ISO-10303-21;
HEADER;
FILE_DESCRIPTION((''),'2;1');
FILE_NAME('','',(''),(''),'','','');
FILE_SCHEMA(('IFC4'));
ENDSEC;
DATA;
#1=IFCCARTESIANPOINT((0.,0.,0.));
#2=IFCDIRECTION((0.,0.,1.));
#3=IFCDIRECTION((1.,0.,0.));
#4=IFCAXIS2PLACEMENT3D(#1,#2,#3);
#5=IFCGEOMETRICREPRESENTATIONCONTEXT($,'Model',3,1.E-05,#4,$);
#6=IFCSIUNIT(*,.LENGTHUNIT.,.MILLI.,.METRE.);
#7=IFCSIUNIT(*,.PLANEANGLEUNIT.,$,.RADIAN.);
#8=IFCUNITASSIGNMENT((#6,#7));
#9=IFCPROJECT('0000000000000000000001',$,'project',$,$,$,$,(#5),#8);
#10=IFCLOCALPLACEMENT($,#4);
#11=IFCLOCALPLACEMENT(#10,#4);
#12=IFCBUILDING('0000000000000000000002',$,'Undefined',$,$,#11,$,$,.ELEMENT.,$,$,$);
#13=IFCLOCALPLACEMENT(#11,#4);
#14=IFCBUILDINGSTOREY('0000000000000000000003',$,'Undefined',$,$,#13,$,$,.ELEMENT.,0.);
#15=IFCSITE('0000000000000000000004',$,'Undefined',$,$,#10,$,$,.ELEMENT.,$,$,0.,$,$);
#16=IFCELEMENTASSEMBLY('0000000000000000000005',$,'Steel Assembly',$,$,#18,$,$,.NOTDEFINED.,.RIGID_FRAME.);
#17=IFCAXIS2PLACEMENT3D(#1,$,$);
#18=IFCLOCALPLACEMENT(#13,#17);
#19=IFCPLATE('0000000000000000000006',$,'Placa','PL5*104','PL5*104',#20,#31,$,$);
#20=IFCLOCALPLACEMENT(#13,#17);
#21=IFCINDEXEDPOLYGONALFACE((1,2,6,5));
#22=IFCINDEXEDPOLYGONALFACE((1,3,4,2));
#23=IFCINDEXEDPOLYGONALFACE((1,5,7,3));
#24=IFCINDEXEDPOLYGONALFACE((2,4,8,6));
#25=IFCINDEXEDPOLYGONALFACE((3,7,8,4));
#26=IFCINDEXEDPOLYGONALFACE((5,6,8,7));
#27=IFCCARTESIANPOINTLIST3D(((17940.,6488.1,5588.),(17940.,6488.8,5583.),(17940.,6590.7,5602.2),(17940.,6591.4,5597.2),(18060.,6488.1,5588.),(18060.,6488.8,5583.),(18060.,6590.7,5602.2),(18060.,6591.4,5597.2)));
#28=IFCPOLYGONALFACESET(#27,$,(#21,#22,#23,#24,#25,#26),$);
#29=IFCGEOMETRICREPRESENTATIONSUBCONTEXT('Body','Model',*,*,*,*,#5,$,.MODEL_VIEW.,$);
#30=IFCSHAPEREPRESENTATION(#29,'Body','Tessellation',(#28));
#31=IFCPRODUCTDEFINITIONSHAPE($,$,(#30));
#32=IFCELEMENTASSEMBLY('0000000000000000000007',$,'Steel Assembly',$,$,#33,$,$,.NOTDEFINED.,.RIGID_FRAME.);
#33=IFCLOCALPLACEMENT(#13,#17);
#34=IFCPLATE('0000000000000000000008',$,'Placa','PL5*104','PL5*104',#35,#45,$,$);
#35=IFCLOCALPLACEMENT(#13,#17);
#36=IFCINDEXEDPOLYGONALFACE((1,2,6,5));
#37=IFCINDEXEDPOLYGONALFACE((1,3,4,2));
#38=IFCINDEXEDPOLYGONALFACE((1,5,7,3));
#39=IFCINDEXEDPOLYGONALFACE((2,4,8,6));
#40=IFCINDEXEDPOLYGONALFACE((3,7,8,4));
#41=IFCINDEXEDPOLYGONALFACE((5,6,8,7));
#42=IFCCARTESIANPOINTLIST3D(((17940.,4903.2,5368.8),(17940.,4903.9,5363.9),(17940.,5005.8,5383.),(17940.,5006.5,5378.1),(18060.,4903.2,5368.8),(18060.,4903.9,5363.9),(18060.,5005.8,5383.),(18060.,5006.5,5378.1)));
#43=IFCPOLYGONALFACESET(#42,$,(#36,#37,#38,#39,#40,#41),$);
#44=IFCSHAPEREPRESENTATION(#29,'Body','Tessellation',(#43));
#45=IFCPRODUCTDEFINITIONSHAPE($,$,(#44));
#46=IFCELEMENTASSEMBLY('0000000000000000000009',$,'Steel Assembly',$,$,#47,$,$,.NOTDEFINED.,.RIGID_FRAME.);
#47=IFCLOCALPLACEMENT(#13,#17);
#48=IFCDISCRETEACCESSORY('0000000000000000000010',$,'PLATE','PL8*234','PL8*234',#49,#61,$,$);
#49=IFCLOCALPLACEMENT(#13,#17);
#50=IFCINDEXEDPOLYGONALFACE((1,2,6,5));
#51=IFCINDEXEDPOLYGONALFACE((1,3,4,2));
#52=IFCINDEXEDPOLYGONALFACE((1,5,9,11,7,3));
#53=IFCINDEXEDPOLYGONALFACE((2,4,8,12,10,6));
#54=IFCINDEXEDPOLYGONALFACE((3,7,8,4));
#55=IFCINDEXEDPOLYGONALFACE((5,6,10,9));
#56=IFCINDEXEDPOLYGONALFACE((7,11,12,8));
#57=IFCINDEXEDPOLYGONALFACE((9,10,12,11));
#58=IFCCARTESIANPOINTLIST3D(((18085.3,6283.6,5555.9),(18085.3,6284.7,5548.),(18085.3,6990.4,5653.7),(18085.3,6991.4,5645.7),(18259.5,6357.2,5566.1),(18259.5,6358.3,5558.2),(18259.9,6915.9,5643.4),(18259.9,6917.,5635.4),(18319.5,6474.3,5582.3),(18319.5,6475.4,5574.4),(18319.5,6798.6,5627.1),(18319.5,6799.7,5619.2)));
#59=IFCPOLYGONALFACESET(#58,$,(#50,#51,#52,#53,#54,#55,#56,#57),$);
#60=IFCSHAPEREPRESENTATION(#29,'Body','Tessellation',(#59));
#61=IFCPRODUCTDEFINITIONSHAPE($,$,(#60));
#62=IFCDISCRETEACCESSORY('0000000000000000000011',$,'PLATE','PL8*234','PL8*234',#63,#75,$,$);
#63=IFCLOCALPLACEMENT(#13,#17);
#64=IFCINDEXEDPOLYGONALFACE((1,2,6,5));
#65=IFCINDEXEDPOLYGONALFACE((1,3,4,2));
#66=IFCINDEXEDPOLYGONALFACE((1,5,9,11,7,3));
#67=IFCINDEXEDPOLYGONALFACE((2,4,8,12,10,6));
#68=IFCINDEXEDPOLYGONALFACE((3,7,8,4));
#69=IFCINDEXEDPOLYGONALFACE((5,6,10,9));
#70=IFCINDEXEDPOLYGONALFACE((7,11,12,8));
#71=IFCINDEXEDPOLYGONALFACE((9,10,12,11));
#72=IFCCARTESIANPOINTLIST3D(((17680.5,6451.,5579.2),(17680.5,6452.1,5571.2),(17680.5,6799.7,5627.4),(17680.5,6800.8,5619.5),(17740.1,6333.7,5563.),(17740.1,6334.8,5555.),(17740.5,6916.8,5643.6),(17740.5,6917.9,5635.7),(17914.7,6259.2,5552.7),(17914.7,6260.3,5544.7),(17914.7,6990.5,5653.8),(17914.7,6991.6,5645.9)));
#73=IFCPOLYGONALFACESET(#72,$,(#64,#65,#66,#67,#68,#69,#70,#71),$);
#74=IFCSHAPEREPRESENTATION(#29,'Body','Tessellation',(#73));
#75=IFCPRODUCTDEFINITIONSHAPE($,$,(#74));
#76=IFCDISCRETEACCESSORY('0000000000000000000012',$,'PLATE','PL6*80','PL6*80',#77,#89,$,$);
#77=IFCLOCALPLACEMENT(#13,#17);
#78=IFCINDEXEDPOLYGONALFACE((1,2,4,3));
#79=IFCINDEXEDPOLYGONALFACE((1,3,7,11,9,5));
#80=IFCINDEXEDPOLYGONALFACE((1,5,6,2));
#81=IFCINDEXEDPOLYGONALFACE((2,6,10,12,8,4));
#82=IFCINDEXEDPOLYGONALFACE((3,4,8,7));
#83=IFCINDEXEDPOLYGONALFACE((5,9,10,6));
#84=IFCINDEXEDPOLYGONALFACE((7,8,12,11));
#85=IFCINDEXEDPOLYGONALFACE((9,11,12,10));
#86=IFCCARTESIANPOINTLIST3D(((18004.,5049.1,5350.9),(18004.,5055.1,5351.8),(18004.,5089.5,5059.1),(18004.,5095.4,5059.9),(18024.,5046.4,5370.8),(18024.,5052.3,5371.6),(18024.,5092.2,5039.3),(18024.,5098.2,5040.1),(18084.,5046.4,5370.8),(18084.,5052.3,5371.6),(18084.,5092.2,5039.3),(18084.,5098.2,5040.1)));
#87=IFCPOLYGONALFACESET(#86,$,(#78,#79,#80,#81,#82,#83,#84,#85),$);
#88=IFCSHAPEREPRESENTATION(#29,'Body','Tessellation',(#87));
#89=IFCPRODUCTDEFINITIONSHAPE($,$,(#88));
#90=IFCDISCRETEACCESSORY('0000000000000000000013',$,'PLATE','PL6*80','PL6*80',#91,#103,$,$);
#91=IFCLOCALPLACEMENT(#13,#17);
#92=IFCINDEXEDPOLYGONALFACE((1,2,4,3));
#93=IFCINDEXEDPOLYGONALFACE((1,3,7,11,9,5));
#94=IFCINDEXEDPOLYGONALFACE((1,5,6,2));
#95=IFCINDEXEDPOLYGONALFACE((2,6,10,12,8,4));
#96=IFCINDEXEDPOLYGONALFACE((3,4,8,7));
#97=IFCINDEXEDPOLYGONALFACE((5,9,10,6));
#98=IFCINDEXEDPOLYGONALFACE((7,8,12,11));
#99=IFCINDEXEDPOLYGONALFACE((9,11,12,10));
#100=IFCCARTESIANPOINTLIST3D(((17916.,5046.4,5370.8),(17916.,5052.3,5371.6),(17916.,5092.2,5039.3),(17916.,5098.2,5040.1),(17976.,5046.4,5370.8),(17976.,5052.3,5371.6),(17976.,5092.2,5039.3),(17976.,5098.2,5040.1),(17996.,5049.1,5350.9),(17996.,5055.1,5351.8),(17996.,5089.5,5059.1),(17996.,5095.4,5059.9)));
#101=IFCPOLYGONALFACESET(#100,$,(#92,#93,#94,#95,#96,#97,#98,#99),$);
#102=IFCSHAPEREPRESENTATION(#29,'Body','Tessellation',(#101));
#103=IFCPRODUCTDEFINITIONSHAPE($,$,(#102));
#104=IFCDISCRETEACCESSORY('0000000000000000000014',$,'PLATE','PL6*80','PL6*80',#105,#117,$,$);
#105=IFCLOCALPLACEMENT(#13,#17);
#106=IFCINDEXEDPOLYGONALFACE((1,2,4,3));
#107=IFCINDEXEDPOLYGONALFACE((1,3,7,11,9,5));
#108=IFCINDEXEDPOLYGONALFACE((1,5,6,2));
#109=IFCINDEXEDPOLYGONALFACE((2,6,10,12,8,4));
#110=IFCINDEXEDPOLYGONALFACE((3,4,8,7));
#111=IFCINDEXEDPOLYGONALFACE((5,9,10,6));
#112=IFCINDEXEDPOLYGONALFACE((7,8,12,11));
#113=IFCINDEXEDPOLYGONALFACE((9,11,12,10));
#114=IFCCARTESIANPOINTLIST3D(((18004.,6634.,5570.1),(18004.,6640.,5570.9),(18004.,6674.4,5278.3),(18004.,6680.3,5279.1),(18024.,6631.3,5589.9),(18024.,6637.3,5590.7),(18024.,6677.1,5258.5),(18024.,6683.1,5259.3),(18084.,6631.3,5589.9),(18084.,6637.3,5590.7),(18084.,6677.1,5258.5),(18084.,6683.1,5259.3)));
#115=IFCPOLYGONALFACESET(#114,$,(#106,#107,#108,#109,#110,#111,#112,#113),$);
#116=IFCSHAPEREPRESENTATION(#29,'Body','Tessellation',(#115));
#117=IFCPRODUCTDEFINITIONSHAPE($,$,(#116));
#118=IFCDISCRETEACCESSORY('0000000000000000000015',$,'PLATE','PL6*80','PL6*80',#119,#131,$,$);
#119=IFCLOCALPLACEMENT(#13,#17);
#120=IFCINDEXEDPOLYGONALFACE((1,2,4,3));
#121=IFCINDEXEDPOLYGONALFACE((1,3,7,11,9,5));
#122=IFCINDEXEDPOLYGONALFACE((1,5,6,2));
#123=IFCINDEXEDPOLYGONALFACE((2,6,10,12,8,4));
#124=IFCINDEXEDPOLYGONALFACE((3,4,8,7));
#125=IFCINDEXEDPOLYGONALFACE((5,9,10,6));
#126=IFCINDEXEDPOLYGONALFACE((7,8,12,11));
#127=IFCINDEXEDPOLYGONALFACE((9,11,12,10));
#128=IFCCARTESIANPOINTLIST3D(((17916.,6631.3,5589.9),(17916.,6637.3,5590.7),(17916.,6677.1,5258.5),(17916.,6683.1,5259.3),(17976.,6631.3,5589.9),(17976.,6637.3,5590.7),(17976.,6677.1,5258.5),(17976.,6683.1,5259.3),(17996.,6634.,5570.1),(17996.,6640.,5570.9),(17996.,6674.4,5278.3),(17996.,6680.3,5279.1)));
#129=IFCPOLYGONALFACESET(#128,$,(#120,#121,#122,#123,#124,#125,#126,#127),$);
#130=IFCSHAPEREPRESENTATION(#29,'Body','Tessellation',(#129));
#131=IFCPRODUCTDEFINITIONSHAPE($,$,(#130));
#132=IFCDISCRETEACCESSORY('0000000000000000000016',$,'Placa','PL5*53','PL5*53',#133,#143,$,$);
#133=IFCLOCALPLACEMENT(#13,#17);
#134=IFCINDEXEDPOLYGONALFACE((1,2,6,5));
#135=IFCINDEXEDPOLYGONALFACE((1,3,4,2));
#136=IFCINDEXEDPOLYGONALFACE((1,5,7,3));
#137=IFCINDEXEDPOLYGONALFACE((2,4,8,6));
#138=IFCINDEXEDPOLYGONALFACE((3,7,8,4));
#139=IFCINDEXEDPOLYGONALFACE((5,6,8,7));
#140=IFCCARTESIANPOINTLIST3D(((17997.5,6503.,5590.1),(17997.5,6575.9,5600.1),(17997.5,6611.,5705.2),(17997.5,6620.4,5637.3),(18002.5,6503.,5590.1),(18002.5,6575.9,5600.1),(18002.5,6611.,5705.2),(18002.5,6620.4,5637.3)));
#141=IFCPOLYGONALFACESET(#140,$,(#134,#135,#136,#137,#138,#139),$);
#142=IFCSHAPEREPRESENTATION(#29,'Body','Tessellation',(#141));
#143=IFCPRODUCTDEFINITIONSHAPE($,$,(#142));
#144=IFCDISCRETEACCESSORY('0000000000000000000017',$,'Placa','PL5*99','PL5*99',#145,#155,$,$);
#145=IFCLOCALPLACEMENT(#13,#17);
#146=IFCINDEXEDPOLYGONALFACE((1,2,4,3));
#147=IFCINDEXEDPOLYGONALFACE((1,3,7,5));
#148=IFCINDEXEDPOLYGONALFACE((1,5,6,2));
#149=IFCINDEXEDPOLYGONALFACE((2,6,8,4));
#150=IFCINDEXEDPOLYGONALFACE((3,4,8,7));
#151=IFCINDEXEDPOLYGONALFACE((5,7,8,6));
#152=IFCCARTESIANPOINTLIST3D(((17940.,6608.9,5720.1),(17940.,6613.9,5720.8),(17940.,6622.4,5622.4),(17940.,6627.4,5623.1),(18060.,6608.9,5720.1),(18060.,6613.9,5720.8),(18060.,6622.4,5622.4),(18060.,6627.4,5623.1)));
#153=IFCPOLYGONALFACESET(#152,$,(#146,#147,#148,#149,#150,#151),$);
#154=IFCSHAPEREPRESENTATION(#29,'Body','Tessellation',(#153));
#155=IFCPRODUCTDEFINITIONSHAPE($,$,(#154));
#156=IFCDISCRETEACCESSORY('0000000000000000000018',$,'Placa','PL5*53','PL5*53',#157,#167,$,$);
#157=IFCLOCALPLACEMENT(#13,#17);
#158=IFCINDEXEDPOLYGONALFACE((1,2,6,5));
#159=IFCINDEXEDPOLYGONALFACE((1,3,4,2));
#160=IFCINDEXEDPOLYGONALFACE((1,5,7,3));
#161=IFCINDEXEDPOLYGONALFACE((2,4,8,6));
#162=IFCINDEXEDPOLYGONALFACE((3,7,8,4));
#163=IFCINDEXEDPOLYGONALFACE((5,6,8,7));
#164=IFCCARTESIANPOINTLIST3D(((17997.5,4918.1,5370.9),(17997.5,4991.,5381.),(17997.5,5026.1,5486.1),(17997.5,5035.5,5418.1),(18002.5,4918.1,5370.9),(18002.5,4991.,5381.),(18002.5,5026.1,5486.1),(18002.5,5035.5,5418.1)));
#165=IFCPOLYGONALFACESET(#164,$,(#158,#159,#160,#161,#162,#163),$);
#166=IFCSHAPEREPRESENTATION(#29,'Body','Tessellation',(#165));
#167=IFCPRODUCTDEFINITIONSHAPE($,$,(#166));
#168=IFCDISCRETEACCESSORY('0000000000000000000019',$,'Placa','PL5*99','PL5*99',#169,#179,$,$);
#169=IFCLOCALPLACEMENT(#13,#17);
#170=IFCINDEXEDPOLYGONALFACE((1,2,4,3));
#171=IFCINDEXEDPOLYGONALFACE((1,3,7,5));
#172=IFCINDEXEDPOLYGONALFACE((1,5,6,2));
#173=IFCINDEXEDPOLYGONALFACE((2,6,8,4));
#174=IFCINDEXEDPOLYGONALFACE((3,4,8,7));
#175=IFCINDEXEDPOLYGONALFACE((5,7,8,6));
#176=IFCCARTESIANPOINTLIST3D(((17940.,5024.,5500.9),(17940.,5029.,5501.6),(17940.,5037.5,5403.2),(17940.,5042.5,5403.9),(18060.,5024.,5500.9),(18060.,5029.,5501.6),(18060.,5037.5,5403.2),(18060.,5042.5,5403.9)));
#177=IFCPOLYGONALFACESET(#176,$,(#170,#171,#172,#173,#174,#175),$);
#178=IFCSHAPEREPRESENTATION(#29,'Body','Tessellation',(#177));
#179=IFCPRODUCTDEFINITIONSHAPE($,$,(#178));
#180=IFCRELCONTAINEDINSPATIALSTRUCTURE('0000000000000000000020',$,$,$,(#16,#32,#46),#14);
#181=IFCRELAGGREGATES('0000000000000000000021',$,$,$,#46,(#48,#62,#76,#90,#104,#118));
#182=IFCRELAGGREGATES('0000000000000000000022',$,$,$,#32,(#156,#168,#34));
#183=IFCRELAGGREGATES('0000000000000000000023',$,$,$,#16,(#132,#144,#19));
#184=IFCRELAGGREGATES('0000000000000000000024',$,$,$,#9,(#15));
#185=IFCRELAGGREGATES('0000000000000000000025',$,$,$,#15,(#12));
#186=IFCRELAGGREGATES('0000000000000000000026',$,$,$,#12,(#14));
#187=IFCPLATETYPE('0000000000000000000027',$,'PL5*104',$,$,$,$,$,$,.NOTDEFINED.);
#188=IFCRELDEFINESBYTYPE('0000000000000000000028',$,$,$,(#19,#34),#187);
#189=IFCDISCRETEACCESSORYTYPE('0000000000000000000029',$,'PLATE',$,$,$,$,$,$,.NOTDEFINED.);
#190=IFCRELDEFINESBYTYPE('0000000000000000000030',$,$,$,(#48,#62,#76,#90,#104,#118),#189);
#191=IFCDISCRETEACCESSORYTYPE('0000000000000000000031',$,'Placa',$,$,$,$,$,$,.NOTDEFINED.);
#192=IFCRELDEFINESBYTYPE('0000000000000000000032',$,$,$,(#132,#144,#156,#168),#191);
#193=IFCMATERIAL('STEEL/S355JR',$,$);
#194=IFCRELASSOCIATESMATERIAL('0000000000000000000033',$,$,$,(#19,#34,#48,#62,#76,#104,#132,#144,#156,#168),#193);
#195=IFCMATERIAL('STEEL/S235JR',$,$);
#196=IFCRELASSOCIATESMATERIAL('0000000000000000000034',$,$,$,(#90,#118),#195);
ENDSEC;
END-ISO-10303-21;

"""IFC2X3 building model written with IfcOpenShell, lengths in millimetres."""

from ifc_helpers import new_model, si_unit, frame, origin_with_axes, place, context, subcontext, project, spatial, polyline, outline, extrude, material, type_object, element, aggregate, save


model = new_model("IFC2X3")

# Units and contexts
model_context = context("Model", 3, precision=1e-05, world=origin_with_axes())
body_context = subcontext(model_context, "Body", "Model", "MODEL_VIEW")
ifc_project = project(units=[si_unit("LENGTHUNIT", "METRE", prefix="MILLI"), si_unit("PLANEANGLEUNIT", "RADIAN")], contexts=[model_context])

# Site, building, storey
site_placement = place(None, origin_with_axes())
site = spatial("IfcSite", under=ifc_project, at=site_placement, Name="Undefined", CompositionType="ELEMENT", RefElevation=0.0)
building_placement = place(site_placement, origin_with_axes())
building = spatial("IfcBuilding", under=site, at=building_placement, Name="Undefined", CompositionType="ELEMENT")
storey_placement = place(building_placement, origin_with_axes())
storey = spatial("IfcBuildingStorey", under=building, at=storey_placement, Name="Undefined", CompositionType="ELEMENT", Elevation=0.0)

# Shared definitions
ifc_material_1 = material(Name="STEEL/S355JR")

# Element assemblies, plates
assembly_1_placement = place(storey_placement, origin_with_axes())
assembly_1 = element("IfcElementAssembly", 1, at=assembly_1_placement, inside=storey, Name="Steel Assembly", AssemblyPlace="NOTDEFINED", PredefinedType="RIGID_FRAME")
plate_type = type_object("IfcPlateType", Name="PL5*104", PredefinedType="NOTDEFINED")
plate_1_placement = place(assembly_1_placement, frame((17940.0, 6591.1, 5599.7), z_axis=(0.0, -0.136905, 0.990584), x_axis=(0.0, -0.990584, -0.136905)))
plate_1 = element("IfcPlate", 2, at=plate_1_placement, type_object=plate_type, material=ifc_material_1, Name="Placa", Description="PL5*104", ObjectType="PL5*104", context=body_context, shape_type="SweptSolid", body=[
    extrude(outline(polyline([(0.0, 0.0), (103.6, 0.0), (103.6, 120.0), (0.0, 120.0), (0.0, 0.0)])), frame((0.0, 0.0, -2.5), z_axis=(0.0, 0.0, 1.0), x_axis=(1.0, 0.0, 0.0)), (0.0, 0.0, 1.0), 5.0),
])
assembly_2_placement = place(storey_placement, origin_with_axes())
assembly_2 = element("IfcElementAssembly", 3, at=assembly_2_placement, inside=storey, Name="Steel Assembly", AssemblyPlace="NOTDEFINED", PredefinedType="RIGID_FRAME")
plate_2_placement = place(assembly_2_placement, frame((17940.0, 5006.2, 5380.5), z_axis=(0.0, -0.136905, 0.990584), x_axis=(0.0, -0.990584, -0.136905)))
plate_2 = element("IfcPlate", 4, at=plate_2_placement, type_object=plate_type, material=ifc_material_1, Name="Placa", Description="PL5*104", ObjectType="PL5*104", context=body_context, shape_type="SweptSolid", body=[
    extrude(outline(polyline([(0.0, 0.0), (103.6, 0.0), (103.6, 120.0), (0.0, 120.0), (0.0, 0.0)])), frame((0.0, 0.0, -2.5), z_axis=(0.0, 0.0, 1.0), x_axis=(1.0, 0.0, 0.0)), (0.0, 0.0, 1.0), 5.0),
])

# Element assembly, discrete accessories
assembly_3_placement = place(storey_placement, origin_with_axes())
assembly_3 = element("IfcElementAssembly", 5, at=assembly_3_placement, inside=storey, Name="Steel Assembly", AssemblyPlace="NOTDEFINED", PredefinedType="RIGID_FRAME")
discrete_accessory_type_1 = type_object("IfcDiscreteAccessoryType", Name="PLATE")
discrete_accessory_1_placement = place(assembly_3_placement, frame((18085.3, 6990.9, 5649.7), z_axis=(-0.000018, -0.13698, 0.990574), x_axis=(0.0, -0.990574, -0.13698)))
discrete_accessory_1 = element("IfcDiscreteAccessory", 6, at=discrete_accessory_1_placement, type_object=discrete_accessory_type_1, material=ifc_material_1, Name="PLATE", Description="PL8*234", ObjectType="PL8*234", context=body_context, shape_type="SweptSolid", body=[
    extrude(outline(polyline([(0.0, 0.0), (713.5, 0.0), (639.1, 174.2), (520.9, 234.3), (193.6, 234.3), (75.2, 174.6), (0.0, 0.0)])), frame((0.0, 0.0, -4.0), z_axis=(0.0, 0.0, 1.0), x_axis=(1.0, 0.0, 0.0)), (0.0, 0.0, 1.0), 8.0),
])
discrete_accessory_2_placement = place(assembly_3_placement, frame((17914.7, 6259.8, 5548.7), z_axis=(-0.000018, -0.13698, 0.990574), x_axis=(0.0, 0.990574, 0.13698)))
discrete_accessory_2 = element("IfcDiscreteAccessory", 7, at=discrete_accessory_2_placement, type_object=discrete_accessory_type_1, material=ifc_material_1, Name="PLATE", Description="PL8*234", ObjectType="PL8*234", context=body_context, shape_type="SweptSolid", body=[
    extrude(outline(polyline([(0.0, 0.0), (738.2, 0.0), (663.9, 174.2), (545.6, 234.3), (193.6, 234.3), (75.2, 174.6), (0.0, 0.0)])), frame((0.0, 0.0, -4.0), z_axis=(0.0, 0.0, 1.0), x_axis=(1.0, 0.0, 0.0)), (0.0, 0.0, 1.0), 8.0),
])
discrete_accessory_3_placement = place(assembly_3_placement, frame((18084.0, 5095.2, 5039.7), z_axis=(0.0, 0.990574, 0.13698), x_axis=(-1.0, 0.0, 0.0)))
discrete_accessory_3 = element("IfcDiscreteAccessory", 8, at=discrete_accessory_3_placement, type_object=discrete_accessory_type_1, material=ifc_material_1, Name="PLATE", Description="PL6*80", ObjectType="PL6*80", context=body_context, shape_type="SweptSolid", body=[
    extrude(outline(polyline([(0.0, 0.0), (60.0, 0.0), (80.0, 20.0), (80.0, 314.6), (60.0, 334.6), (0.0, 334.6), (0.0, 0.0)])), frame((0.0, 0.0, -3.0), z_axis=(0.0, 0.0, 1.0), x_axis=(1.0, 0.0, 0.0)), (0.0, 0.0, 1.0), 6.0),
])
ifc_material_2 = material(Name="STEEL/S235JR")
discrete_accessory_4_placement = place(assembly_3_placement, frame((17996.0, 5095.2, 5039.7), z_axis=(0.0, 0.990574, 0.13698), x_axis=(-1.0, 0.0, 0.0)))
discrete_accessory_4 = element("IfcDiscreteAccessory", 9, at=discrete_accessory_4_placement, type_object=discrete_accessory_type_1, material=ifc_material_2, Name="PLATE", Description="PL6*80", ObjectType="PL6*80", context=body_context, shape_type="SweptSolid", body=[
    extrude(outline(polyline([(0.0, 20.0), (20.0, 0.0), (80.0, 0.0), (80.0, 334.6), (20.0, 334.6), (0.0, 314.6), (0.0, 20.0)])), frame((0.0, 0.0, -3.0), z_axis=(0.0, 0.0, 1.0), x_axis=(1.0, 0.0, 0.0)), (0.0, 0.0, 1.0), 6.0),
])
discrete_accessory_5_placement = place(assembly_3_placement, frame((18084.0, 6680.1, 5258.9), z_axis=(0.0, 0.990574, 0.13698), x_axis=(-1.0, 0.0, 0.0)))
discrete_accessory_5 = element("IfcDiscreteAccessory", 10, at=discrete_accessory_5_placement, type_object=discrete_accessory_type_1, material=ifc_material_1, Name="PLATE", Description="PL6*80", ObjectType="PL6*80", context=body_context, shape_type="SweptSolid", body=[
    extrude(outline(polyline([(0.0, 0.0), (60.0, 0.0), (80.0, 20.0), (80.0, 314.6), (60.0, 334.6), (0.0, 334.6), (0.0, 0.0)])), frame((0.0, 0.0, -3.0), z_axis=(0.0, 0.0, 1.0), x_axis=(1.0, 0.0, 0.0)), (0.0, 0.0, 1.0), 6.0),
])
discrete_accessory_6_placement = place(assembly_3_placement, frame((17996.0, 6680.1, 5258.9), z_axis=(0.0, 0.990574, 0.13698), x_axis=(-1.0, 0.0, 0.0)))
discrete_accessory_6 = element("IfcDiscreteAccessory", 11, at=discrete_accessory_6_placement, type_object=discrete_accessory_type_1, material=ifc_material_2, Name="PLATE", Description="PL6*80", ObjectType="PL6*80", context=body_context, shape_type="SweptSolid", body=[
    extrude(outline(polyline([(0.0, 20.0), (20.0, 0.0), (80.0, 0.0), (80.0, 334.6), (20.0, 334.6), (0.0, 314.6), (0.0, 20.0)])), frame((0.0, 0.0, -3.0), z_axis=(0.0, 0.0, 1.0), x_axis=(1.0, 0.0, 0.0)), (0.0, 0.0, 1.0), 6.0),
])
aggregate(assembly_3, [discrete_accessory_1, discrete_accessory_2, discrete_accessory_3, discrete_accessory_4, discrete_accessory_5, discrete_accessory_6])

# Discrete accessories
discrete_accessory_type_2 = type_object("IfcDiscreteAccessoryType", Name="Placa")
discrete_accessory_7_placement = place(assembly_1_placement, frame((18000.0, 6611.0, 5705.2), z_axis=(1.0, 0.0, 0.0), x_axis=(0.0, -0.684057, -0.729429)))
discrete_accessory_7 = element("IfcDiscreteAccessory", 12, at=discrete_accessory_7_placement, type_object=discrete_accessory_type_2, material=ifc_material_1, Name="Placa", Description="PL5*53", ObjectType="PL5*53", context=body_context, shape_type="SweptSolid", body=[
    extrude(outline(polyline([(0.0, 0.0), (157.9, 0.0), (100.7, 46.3), (43.1, 53.3), (0.0, 0.0)])), frame((0.0, 0.0, -2.5), z_axis=(0.0, 0.0, 1.0), x_axis=(1.0, 0.0, 0.0)), (0.0, 0.0, 1.0), 5.0),
])
discrete_accessory_8_placement = place(assembly_1_placement, frame((17940.0, 6624.9, 5622.8), z_axis=(0.0, 0.990592, 0.136849), x_axis=(0.0, -0.136849, 0.990592)))
discrete_accessory_8 = element("IfcDiscreteAccessory", 13, at=discrete_accessory_8_placement, type_object=discrete_accessory_type_2, material=ifc_material_1, Name="Placa", Description="PL5*99", ObjectType="PL5*99", context=body_context, shape_type="SweptSolid", body=[
    extrude(outline(polyline([(0.0, 0.0), (98.6, 0.0), (98.6, 120.0), (0.0, 120.0), (0.0, 0.0)])), frame((0.0, 0.0, -2.5), z_axis=(0.0, 0.0, 1.0), x_axis=(1.0, 0.0, 0.0)), (0.0, 0.0, 1.0), 5.0),
])
discrete_accessory_9_placement = place(assembly_2_placement, frame((18000.0, 5026.1, 5486.1), z_axis=(1.0, 0.0, 0.0), x_axis=(0.0, -0.684057, -0.729429)))
discrete_accessory_9 = element("IfcDiscreteAccessory", 14, at=discrete_accessory_9_placement, type_object=discrete_accessory_type_2, material=ifc_material_1, Name="Placa", Description="PL5*53", ObjectType="PL5*53", context=body_context, shape_type="SweptSolid", body=[
    extrude(outline(polyline([(0.0, 0.0), (157.9, 0.0), (100.7, 46.3), (43.1, 53.3), (0.0, 0.0)])), frame((0.0, 0.0, -2.5), z_axis=(0.0, 0.0, 1.0), x_axis=(1.0, 0.0, 0.0)), (0.0, 0.0, 1.0), 5.0),
])
discrete_accessory_10_placement = place(assembly_2_placement, frame((17940.0, 5040.0, 5403.6), z_axis=(0.0, 0.990592, 0.136849), x_axis=(0.0, -0.136849, 0.990592)))
discrete_accessory_10 = element("IfcDiscreteAccessory", 15, at=discrete_accessory_10_placement, type_object=discrete_accessory_type_2, material=ifc_material_1, Name="Placa", Description="PL5*99", ObjectType="PL5*99", context=body_context, shape_type="SweptSolid", body=[
    extrude(outline(polyline([(0.0, 0.0), (98.6, 0.0), (98.6, 120.0), (0.0, 120.0), (0.0, 0.0)])), frame((0.0, 0.0, -2.5), z_axis=(0.0, 0.0, 1.0), x_axis=(1.0, 0.0, 0.0)), (0.0, 0.0, 1.0), 5.0),
])

aggregate(assembly_2, [discrete_accessory_9, discrete_accessory_10, plate_2])

aggregate(assembly_1, [discrete_accessory_7, discrete_accessory_8, plate_1])

save(model, "model.ifc")
